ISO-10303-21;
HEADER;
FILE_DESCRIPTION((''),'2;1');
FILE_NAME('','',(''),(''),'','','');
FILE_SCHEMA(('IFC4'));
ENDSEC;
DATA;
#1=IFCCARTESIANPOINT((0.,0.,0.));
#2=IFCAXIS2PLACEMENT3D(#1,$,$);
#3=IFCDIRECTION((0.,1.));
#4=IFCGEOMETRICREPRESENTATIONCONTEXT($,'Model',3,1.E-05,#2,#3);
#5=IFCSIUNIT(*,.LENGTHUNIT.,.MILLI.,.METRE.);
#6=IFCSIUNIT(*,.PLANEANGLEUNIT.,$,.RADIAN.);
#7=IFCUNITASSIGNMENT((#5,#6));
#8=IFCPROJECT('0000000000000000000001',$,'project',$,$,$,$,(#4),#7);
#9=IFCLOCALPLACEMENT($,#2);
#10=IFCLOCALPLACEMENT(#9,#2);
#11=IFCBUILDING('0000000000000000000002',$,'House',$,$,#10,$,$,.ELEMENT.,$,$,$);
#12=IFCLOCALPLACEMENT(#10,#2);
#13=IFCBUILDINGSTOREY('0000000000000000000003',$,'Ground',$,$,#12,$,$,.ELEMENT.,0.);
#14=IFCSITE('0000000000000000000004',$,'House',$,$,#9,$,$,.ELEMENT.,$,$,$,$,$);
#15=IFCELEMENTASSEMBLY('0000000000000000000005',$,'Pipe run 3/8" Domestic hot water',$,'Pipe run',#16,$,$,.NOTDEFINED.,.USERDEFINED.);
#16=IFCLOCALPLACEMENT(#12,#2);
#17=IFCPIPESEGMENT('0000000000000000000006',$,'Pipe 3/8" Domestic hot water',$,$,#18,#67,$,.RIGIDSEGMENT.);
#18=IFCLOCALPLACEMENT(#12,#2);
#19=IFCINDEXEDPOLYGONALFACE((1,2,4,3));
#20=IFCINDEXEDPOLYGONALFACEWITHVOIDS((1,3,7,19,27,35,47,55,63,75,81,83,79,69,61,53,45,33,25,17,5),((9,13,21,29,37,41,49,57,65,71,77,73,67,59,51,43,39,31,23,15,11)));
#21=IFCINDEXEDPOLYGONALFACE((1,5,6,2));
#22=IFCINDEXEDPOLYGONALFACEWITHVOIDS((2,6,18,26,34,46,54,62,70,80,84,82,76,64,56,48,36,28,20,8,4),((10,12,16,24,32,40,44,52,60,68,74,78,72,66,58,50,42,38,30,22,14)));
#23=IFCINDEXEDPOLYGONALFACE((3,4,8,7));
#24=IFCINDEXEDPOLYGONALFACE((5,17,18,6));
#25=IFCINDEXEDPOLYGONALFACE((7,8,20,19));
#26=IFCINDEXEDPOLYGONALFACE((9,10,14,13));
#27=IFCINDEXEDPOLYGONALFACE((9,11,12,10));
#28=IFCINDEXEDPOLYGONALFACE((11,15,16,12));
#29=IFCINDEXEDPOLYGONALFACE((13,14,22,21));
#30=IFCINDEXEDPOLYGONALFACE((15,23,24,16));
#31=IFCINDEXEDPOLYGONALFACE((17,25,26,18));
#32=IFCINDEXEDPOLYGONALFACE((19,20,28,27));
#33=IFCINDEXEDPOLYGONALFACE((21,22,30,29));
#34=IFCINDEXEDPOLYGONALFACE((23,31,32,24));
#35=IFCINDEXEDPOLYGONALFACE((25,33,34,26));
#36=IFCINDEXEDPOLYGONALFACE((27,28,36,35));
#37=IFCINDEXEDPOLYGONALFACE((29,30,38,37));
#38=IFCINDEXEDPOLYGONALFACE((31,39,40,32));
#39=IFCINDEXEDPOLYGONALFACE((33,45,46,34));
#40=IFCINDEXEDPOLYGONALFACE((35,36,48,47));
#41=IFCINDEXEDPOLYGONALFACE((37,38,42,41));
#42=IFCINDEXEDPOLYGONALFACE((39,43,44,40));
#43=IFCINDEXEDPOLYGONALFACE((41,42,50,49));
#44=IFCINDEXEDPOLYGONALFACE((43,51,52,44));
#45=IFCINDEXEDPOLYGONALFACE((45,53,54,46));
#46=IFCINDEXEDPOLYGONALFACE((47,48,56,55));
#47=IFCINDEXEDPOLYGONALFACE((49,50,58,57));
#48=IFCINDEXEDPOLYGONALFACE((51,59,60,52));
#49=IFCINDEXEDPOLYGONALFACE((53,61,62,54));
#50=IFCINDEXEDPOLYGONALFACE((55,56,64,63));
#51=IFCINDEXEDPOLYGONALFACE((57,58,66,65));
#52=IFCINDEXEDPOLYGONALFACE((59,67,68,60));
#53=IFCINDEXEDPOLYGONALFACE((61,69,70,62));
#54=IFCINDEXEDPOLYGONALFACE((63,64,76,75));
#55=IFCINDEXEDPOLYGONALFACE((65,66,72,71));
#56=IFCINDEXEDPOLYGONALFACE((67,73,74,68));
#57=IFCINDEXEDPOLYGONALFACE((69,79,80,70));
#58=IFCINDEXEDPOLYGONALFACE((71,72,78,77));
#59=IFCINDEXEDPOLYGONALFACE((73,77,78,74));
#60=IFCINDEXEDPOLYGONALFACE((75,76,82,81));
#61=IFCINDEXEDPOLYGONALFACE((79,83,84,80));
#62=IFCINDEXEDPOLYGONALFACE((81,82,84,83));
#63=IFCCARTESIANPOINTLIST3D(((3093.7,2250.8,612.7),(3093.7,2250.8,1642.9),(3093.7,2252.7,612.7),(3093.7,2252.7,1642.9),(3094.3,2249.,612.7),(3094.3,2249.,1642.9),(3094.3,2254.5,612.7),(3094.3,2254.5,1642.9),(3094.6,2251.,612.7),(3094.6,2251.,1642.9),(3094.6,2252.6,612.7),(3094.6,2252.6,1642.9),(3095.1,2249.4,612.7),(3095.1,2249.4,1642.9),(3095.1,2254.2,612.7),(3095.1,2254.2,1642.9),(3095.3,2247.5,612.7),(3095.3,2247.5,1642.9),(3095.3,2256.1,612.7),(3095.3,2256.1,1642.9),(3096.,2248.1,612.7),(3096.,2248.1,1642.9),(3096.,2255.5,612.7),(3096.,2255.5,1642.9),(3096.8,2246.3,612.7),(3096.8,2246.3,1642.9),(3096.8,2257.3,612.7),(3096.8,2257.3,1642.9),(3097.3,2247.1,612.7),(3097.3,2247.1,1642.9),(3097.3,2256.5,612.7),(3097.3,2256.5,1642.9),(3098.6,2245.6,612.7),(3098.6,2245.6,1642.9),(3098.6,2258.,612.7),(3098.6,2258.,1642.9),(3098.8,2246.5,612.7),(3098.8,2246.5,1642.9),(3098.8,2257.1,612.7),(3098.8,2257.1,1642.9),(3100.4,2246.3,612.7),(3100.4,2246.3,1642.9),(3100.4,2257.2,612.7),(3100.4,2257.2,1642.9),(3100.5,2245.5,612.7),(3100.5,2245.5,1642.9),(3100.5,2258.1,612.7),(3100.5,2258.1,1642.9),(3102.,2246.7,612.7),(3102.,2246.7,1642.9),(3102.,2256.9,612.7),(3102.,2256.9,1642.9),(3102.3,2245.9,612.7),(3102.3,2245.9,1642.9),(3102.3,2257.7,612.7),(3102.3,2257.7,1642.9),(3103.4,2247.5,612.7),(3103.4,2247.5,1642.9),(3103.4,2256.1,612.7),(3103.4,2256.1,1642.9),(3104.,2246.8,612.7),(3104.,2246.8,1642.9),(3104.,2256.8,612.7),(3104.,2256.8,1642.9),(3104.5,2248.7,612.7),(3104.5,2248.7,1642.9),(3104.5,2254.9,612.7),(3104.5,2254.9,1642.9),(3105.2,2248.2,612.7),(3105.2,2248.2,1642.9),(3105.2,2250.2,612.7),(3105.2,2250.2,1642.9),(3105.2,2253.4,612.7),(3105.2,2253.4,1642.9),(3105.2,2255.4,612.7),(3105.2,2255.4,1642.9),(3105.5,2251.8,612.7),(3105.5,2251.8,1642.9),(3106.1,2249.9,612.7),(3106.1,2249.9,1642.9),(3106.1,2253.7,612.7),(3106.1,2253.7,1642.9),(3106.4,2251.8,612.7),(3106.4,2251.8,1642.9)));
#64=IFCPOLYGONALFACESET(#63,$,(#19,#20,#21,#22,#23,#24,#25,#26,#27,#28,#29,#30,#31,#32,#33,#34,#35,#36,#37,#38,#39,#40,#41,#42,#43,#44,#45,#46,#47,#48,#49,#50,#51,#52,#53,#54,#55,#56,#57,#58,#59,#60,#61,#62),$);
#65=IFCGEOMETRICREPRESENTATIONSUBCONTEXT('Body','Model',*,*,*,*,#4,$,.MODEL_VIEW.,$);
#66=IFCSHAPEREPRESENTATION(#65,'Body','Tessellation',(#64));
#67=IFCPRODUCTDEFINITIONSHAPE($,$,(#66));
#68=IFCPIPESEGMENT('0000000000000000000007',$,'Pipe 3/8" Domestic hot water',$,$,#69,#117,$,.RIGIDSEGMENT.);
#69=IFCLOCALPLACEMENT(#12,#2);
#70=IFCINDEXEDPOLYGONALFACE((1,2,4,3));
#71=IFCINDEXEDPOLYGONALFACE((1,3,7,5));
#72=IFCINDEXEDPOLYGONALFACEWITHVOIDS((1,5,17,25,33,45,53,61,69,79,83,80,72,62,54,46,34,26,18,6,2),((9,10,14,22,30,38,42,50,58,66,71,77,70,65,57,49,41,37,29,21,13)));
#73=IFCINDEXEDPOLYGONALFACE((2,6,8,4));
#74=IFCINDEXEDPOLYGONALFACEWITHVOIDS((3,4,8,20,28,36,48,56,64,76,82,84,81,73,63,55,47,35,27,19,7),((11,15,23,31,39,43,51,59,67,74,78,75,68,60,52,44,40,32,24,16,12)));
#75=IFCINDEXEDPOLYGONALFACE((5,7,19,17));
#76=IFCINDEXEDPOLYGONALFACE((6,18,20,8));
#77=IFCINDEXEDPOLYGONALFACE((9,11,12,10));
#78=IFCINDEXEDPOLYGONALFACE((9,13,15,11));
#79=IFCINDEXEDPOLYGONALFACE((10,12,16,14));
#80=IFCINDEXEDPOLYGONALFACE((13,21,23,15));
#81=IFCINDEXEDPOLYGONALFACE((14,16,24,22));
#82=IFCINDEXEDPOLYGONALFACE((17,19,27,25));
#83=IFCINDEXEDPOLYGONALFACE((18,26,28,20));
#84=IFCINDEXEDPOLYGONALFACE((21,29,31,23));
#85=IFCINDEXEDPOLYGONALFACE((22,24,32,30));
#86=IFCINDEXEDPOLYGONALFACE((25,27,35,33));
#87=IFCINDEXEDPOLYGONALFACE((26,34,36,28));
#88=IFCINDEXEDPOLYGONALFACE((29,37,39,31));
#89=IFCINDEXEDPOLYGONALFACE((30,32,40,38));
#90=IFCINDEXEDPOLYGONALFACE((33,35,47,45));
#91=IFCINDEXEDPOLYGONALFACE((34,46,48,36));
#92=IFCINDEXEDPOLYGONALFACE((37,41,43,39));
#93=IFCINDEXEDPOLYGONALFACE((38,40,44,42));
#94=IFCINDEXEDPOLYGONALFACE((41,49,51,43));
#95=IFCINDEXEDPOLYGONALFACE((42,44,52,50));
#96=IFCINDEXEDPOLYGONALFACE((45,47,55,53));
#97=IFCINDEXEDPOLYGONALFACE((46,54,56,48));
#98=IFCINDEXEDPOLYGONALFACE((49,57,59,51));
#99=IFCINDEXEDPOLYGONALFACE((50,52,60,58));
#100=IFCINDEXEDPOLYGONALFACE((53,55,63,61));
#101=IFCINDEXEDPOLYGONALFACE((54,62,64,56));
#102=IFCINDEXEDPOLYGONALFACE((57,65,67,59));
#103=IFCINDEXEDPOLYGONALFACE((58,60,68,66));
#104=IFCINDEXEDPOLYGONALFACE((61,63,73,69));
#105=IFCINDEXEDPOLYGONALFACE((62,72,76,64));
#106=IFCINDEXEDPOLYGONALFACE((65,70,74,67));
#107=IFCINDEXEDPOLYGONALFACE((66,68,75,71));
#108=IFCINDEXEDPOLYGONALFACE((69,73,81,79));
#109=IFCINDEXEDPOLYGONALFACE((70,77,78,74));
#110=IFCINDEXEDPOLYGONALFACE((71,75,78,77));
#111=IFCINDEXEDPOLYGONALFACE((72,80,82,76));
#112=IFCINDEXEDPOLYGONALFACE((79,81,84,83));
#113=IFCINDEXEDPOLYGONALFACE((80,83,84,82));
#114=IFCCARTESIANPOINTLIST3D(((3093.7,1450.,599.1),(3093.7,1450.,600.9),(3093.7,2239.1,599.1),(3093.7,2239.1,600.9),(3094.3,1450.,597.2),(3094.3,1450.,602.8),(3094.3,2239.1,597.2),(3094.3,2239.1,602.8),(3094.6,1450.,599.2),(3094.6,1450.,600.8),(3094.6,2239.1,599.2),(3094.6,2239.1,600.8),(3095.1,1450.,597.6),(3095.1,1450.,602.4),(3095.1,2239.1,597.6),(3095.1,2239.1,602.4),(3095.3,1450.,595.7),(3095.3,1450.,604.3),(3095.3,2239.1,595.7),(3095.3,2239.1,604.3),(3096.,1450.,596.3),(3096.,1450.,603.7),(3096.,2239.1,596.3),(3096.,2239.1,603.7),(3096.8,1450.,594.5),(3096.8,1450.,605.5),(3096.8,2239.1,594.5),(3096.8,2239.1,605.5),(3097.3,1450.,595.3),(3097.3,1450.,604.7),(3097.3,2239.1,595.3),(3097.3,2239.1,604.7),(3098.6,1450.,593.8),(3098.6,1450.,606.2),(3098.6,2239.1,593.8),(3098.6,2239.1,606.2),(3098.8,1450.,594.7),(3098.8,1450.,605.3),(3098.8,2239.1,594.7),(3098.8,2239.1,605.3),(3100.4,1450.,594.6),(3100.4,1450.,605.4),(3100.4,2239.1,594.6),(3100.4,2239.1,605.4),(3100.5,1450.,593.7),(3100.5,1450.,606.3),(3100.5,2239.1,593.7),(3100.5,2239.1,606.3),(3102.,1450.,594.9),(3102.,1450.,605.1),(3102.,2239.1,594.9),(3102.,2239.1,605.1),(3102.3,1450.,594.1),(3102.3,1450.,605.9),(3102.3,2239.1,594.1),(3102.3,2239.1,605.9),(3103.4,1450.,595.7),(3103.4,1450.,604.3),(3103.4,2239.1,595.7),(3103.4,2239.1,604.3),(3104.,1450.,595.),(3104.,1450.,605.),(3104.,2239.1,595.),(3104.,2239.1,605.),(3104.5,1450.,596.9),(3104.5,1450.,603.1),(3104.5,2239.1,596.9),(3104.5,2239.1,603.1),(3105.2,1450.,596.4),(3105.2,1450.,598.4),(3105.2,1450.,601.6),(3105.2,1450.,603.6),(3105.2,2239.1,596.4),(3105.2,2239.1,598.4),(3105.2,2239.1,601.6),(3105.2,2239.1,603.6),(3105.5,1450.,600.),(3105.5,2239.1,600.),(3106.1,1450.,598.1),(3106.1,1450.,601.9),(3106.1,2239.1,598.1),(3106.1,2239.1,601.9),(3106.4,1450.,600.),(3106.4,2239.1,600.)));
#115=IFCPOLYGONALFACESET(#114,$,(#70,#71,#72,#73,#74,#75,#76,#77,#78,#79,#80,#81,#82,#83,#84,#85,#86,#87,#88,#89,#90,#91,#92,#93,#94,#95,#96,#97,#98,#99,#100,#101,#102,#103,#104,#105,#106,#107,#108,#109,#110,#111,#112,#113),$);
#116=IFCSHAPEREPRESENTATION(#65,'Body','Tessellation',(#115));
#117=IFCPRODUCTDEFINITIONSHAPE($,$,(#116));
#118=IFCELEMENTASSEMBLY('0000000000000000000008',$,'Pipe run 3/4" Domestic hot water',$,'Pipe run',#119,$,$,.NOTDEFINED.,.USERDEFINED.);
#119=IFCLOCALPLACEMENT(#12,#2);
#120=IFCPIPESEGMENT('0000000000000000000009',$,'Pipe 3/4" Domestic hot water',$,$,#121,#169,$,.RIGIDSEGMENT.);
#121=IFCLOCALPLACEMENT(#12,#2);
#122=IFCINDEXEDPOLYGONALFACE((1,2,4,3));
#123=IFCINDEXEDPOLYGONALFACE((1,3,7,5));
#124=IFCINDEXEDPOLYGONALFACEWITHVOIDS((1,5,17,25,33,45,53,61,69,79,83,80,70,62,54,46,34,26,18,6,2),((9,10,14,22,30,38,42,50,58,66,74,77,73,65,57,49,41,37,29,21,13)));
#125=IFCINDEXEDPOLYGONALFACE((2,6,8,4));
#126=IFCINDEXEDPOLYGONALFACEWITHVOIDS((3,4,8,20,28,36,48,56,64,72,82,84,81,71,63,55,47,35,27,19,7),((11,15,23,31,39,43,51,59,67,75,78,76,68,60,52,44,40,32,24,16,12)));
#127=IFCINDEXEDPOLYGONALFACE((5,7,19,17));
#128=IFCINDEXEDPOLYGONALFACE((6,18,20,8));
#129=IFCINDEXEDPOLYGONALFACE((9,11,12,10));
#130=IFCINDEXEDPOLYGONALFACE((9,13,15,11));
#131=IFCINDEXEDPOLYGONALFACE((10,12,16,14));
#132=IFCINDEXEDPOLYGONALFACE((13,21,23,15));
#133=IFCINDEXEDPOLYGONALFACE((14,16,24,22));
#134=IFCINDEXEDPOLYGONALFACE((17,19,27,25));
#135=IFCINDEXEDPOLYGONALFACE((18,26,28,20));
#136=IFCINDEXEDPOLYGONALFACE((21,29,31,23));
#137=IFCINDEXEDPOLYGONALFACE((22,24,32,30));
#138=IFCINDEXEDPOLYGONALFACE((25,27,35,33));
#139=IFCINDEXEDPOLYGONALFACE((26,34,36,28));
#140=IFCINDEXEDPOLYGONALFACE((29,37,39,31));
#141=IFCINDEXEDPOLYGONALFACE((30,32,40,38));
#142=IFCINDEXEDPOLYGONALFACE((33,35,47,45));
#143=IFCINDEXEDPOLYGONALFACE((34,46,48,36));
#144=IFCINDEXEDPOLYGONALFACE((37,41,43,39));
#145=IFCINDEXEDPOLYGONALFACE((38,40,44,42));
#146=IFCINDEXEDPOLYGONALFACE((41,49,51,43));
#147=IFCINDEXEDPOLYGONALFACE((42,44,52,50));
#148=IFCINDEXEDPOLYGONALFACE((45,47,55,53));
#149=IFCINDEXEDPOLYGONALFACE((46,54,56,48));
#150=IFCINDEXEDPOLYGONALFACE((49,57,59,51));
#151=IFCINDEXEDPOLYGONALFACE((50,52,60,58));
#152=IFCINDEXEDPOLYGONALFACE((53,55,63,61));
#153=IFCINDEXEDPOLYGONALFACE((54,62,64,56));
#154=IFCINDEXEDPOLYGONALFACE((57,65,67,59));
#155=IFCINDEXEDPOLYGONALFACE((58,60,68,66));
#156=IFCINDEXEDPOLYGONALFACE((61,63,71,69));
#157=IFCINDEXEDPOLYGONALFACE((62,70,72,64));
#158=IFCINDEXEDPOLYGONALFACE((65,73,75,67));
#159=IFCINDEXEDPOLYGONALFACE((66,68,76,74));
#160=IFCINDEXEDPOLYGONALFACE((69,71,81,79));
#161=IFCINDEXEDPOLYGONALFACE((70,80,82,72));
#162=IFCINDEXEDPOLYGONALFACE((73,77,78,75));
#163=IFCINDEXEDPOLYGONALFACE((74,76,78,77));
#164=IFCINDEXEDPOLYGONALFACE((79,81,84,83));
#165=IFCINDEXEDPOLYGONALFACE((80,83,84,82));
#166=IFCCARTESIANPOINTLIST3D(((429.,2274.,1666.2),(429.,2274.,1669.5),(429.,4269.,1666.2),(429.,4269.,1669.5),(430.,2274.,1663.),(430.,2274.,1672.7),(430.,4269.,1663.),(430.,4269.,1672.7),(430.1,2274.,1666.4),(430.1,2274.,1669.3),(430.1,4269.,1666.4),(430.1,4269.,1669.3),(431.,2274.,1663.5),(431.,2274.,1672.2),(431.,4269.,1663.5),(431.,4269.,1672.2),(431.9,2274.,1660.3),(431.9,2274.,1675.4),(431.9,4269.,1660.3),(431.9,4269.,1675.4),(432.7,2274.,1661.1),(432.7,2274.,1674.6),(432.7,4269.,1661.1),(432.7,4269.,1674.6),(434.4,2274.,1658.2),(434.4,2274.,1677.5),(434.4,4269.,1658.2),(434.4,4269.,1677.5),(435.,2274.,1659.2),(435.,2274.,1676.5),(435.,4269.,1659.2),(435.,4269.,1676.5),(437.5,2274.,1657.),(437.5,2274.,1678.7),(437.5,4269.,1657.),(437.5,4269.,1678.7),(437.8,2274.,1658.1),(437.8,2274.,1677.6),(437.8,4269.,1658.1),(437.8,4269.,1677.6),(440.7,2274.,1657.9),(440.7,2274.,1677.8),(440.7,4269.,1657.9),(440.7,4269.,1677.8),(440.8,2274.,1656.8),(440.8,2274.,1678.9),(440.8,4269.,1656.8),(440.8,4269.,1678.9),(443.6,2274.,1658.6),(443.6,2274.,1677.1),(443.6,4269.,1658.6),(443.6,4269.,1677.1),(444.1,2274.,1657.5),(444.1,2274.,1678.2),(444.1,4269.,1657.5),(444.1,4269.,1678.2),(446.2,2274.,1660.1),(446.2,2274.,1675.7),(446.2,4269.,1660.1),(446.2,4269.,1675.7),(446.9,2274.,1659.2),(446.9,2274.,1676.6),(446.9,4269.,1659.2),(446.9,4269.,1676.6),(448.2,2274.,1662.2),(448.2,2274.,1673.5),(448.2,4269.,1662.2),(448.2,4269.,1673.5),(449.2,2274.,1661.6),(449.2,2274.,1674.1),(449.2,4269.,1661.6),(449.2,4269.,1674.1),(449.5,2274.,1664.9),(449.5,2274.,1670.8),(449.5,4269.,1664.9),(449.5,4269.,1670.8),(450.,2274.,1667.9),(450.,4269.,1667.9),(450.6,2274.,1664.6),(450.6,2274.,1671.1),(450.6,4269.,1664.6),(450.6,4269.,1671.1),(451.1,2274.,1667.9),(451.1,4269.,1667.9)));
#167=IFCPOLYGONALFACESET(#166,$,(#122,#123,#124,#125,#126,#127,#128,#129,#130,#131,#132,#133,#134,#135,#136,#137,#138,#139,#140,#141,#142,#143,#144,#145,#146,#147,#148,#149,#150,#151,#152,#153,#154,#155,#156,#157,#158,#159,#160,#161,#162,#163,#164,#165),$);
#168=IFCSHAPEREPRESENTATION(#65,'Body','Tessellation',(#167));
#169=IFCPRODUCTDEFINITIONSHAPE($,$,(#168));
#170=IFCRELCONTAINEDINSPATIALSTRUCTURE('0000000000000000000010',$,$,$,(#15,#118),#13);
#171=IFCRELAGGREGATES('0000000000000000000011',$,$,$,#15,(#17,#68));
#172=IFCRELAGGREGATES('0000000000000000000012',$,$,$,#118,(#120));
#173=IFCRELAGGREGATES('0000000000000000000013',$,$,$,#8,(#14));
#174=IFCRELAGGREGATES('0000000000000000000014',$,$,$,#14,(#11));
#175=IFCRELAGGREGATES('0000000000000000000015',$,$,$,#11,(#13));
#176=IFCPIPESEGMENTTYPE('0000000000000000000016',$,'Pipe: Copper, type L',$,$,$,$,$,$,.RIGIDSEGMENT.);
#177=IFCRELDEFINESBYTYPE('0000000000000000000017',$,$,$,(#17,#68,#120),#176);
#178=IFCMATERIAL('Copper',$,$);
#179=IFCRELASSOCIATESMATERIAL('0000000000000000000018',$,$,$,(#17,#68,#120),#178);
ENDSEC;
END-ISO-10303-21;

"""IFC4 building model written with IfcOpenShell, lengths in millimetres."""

from ifc_helpers import new_model, si_unit, direction, frame, origin, origin_with_axes, origin_2d, place, context, subcontext, project, spatial, hollow_circle, extrude, material, type_object, element, aggregate, save


model = new_model("IFC4")

# Units and contexts
model_context = context("Model", 3, precision=1e-05, world=origin(), true_north=direction((0.0, 1.0)))
body_context = subcontext(model_context, "Body", "Model", "MODEL_VIEW")
ifc_project = project(units=[si_unit("LENGTHUNIT", "METRE", prefix="MILLI"), si_unit("PLANEANGLEUNIT", "RADIAN")], contexts=[model_context])

# Site, building, storey
site_placement = place(None, origin())
site = spatial("IfcSite", under=ifc_project, at=site_placement, Name="House", CompositionType="ELEMENT")
building_placement = place(site_placement, origin())
building = spatial("IfcBuilding", under=site, at=building_placement, Name="House", CompositionType="ELEMENT")
storey_placement = place(building_placement, origin())
storey = spatial("IfcBuildingStorey", under=building, at=storey_placement, Name="Ground", CompositionType="ELEMENT", Elevation=0.0)

# Element assemblies, pipe segments
ifc_material = material(Name="Copper")
pipe_segment_type = type_object("IfcPipeSegmentType", Name="Pipe: Copper, type L", PredefinedType="RIGIDSEGMENT")
assembly_1_placement = place(storey_placement, origin_with_axes())
assembly_1 = element("IfcElementAssembly", 1, at=assembly_1_placement, inside=storey, Name="Pipe run 3/8\" Domestic hot water", ObjectType="Pipe run", AssemblyPlace="NOTDEFINED", PredefinedType="USERDEFINED")
pipe_segment_1_placement = place(storey_placement, origin_with_axes())
pipe_segment_1 = element("IfcPipeSegment", 2, at=pipe_segment_1_placement, type_object=pipe_segment_type, material=ifc_material, Name="Pipe 3/8\" Domestic hot water", PredefinedType="RIGIDSEGMENT", context=body_context, shape_type="SweptSolid", body=[
    extrude(hollow_circle(Radius=6.3, WallThickness=0.9, at=origin_2d()), frame((3100.0, 2251.8, 1642.9), z_axis=(0.0, 0.0, -1.0), x_axis=(1.0, 0.0, 0.0)), (0.0, 0.0, 1.0), 1030.2),
])
pipe_segment_2_placement = place(storey_placement, origin_with_axes())
pipe_segment_2 = element("IfcPipeSegment", 3, at=pipe_segment_2_placement, type_object=pipe_segment_type, material=ifc_material, Name="Pipe 3/8\" Domestic hot water", PredefinedType="RIGIDSEGMENT", context=body_context, shape_type="SweptSolid", body=[
    extrude(hollow_circle(Radius=6.3, WallThickness=0.9, at=origin_2d()), frame((3100.0, 2239.1, 600.0), z_axis=(0.0, -1.0, 0.0), x_axis=(1.0, 0.0, 0.0)), (0.0, 0.0, 1.0), 789.1),
])
assembly_2_placement = place(storey_placement, origin_with_axes())
assembly_2 = element("IfcElementAssembly", 4, at=assembly_2_placement, inside=storey, Name="Pipe run 3/4\" Domestic hot water", ObjectType="Pipe run", AssemblyPlace="NOTDEFINED", PredefinedType="USERDEFINED")
pipe_segment_3_placement = place(storey_placement, origin_with_axes())
pipe_segment_3 = element("IfcPipeSegment", 5, at=pipe_segment_3_placement, type_object=pipe_segment_type, material=ifc_material, Name="Pipe 3/4\" Domestic hot water", PredefinedType="RIGIDSEGMENT", context=body_context, shape_type="SweptSolid", body=[
    extrude(hollow_circle(Radius=11.1, WallThickness=1.1, at=origin_2d()), frame((440.0, 4269.0, 1667.9), z_axis=(0.0, -1.0, 0.0), x_axis=(1.0, 0.0, 0.0)), (0.0, 0.0, 1.0), 1995.0),
])

aggregate(assembly_1, [pipe_segment_1, pipe_segment_2])
aggregate(assembly_2, [pipe_segment_3])

save(model, "model.ifc")
